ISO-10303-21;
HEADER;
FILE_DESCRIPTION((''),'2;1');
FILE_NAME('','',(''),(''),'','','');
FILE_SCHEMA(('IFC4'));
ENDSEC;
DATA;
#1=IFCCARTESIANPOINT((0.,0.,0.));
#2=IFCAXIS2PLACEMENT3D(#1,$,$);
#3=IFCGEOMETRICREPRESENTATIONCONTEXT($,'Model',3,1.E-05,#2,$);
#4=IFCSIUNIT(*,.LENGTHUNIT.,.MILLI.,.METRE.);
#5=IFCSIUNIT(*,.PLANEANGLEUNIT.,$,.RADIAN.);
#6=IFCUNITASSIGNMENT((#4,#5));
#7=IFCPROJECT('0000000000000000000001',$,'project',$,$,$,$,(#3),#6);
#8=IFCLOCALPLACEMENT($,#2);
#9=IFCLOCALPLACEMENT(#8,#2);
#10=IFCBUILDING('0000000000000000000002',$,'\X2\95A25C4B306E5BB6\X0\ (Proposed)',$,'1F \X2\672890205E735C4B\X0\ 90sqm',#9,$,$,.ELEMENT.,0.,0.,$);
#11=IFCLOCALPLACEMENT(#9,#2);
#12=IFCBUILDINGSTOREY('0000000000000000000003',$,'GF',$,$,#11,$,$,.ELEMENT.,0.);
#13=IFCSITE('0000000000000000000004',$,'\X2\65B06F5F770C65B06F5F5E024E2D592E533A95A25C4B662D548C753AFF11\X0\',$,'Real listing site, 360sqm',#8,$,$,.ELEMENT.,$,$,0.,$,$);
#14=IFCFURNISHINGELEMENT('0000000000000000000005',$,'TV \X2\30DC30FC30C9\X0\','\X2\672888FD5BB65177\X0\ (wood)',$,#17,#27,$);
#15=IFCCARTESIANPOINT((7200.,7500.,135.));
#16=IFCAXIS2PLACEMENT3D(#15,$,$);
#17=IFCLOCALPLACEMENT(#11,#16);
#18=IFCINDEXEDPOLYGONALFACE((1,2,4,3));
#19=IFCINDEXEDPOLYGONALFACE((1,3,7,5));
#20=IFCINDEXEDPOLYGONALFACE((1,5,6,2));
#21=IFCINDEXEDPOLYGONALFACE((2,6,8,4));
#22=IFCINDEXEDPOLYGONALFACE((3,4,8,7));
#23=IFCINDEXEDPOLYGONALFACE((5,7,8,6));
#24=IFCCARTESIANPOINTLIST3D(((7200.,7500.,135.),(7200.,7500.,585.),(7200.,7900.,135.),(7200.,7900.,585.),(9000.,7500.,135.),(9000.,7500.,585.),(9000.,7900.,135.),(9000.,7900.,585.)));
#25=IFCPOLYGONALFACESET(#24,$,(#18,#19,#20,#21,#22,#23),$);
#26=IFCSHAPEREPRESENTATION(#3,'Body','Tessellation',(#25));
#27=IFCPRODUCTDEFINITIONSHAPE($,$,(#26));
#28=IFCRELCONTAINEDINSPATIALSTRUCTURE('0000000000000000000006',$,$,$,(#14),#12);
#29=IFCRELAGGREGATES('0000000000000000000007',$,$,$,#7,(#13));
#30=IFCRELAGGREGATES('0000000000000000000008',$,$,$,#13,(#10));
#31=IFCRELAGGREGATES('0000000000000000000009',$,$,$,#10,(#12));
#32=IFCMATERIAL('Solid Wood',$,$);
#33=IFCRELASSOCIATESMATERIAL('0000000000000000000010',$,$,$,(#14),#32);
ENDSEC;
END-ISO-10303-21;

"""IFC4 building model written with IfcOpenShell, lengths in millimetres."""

from ifc_helpers import new_model, si_unit, frame, frame_2d, origin, place, context, project, spatial, rectangle, extrude, material, element, save


model = new_model("IFC4")

# Units and contexts
model_context = context("Model", 3, precision=1e-05, world=origin())
ifc_project = project(units=[si_unit("LENGTHUNIT", "METRE", prefix="MILLI"), si_unit("PLANEANGLEUNIT", "RADIAN")], contexts=[model_context])

# Site, building, storey
site_placement = place(None, origin())
site = spatial("IfcSite", under=ifc_project, at=site_placement, Name="新潟県新潟市中央区関屋昭和町１", ObjectType="Real listing site, 360sqm", CompositionType="ELEMENT", RefElevation=0.0)
building_placement = place(site_placement, origin())
building = spatial("IfcBuilding", under=site, at=building_placement, Name="関屋の家 (Proposed)", ObjectType="1F 木造平屋 90sqm", CompositionType="ELEMENT", ElevationOfRefHeight=0.0, ElevationOfTerrain=0.0)
storey_placement = place(building_placement, origin())
storey = spatial("IfcBuildingStorey", under=building, at=storey_placement, Name="GF", CompositionType="ELEMENT", Elevation=0.0)

# Shared definitions
ifc_material_1 = material(Name="Solid Wood")

# Furnishing element
furnishing_1_placement = place(storey_placement, frame((7200.0, 7500.0, 135.0)))
element("IfcFurnishingElement", 1, at=furnishing_1_placement, inside=storey, material=ifc_material_1, Name="TV ボード", Description="木製家具 (wood)", context=model_context, shape_type="SweptSolid", body=[
    extrude(rectangle(XDim=1800.0, YDim=400.0, at=frame_2d((900.0, 200.0))), frame((7200.0, 7500.0, 135.0)), (0.0, 0.0, 1.0), 450.0),
])

save(model, "model.ifc")
